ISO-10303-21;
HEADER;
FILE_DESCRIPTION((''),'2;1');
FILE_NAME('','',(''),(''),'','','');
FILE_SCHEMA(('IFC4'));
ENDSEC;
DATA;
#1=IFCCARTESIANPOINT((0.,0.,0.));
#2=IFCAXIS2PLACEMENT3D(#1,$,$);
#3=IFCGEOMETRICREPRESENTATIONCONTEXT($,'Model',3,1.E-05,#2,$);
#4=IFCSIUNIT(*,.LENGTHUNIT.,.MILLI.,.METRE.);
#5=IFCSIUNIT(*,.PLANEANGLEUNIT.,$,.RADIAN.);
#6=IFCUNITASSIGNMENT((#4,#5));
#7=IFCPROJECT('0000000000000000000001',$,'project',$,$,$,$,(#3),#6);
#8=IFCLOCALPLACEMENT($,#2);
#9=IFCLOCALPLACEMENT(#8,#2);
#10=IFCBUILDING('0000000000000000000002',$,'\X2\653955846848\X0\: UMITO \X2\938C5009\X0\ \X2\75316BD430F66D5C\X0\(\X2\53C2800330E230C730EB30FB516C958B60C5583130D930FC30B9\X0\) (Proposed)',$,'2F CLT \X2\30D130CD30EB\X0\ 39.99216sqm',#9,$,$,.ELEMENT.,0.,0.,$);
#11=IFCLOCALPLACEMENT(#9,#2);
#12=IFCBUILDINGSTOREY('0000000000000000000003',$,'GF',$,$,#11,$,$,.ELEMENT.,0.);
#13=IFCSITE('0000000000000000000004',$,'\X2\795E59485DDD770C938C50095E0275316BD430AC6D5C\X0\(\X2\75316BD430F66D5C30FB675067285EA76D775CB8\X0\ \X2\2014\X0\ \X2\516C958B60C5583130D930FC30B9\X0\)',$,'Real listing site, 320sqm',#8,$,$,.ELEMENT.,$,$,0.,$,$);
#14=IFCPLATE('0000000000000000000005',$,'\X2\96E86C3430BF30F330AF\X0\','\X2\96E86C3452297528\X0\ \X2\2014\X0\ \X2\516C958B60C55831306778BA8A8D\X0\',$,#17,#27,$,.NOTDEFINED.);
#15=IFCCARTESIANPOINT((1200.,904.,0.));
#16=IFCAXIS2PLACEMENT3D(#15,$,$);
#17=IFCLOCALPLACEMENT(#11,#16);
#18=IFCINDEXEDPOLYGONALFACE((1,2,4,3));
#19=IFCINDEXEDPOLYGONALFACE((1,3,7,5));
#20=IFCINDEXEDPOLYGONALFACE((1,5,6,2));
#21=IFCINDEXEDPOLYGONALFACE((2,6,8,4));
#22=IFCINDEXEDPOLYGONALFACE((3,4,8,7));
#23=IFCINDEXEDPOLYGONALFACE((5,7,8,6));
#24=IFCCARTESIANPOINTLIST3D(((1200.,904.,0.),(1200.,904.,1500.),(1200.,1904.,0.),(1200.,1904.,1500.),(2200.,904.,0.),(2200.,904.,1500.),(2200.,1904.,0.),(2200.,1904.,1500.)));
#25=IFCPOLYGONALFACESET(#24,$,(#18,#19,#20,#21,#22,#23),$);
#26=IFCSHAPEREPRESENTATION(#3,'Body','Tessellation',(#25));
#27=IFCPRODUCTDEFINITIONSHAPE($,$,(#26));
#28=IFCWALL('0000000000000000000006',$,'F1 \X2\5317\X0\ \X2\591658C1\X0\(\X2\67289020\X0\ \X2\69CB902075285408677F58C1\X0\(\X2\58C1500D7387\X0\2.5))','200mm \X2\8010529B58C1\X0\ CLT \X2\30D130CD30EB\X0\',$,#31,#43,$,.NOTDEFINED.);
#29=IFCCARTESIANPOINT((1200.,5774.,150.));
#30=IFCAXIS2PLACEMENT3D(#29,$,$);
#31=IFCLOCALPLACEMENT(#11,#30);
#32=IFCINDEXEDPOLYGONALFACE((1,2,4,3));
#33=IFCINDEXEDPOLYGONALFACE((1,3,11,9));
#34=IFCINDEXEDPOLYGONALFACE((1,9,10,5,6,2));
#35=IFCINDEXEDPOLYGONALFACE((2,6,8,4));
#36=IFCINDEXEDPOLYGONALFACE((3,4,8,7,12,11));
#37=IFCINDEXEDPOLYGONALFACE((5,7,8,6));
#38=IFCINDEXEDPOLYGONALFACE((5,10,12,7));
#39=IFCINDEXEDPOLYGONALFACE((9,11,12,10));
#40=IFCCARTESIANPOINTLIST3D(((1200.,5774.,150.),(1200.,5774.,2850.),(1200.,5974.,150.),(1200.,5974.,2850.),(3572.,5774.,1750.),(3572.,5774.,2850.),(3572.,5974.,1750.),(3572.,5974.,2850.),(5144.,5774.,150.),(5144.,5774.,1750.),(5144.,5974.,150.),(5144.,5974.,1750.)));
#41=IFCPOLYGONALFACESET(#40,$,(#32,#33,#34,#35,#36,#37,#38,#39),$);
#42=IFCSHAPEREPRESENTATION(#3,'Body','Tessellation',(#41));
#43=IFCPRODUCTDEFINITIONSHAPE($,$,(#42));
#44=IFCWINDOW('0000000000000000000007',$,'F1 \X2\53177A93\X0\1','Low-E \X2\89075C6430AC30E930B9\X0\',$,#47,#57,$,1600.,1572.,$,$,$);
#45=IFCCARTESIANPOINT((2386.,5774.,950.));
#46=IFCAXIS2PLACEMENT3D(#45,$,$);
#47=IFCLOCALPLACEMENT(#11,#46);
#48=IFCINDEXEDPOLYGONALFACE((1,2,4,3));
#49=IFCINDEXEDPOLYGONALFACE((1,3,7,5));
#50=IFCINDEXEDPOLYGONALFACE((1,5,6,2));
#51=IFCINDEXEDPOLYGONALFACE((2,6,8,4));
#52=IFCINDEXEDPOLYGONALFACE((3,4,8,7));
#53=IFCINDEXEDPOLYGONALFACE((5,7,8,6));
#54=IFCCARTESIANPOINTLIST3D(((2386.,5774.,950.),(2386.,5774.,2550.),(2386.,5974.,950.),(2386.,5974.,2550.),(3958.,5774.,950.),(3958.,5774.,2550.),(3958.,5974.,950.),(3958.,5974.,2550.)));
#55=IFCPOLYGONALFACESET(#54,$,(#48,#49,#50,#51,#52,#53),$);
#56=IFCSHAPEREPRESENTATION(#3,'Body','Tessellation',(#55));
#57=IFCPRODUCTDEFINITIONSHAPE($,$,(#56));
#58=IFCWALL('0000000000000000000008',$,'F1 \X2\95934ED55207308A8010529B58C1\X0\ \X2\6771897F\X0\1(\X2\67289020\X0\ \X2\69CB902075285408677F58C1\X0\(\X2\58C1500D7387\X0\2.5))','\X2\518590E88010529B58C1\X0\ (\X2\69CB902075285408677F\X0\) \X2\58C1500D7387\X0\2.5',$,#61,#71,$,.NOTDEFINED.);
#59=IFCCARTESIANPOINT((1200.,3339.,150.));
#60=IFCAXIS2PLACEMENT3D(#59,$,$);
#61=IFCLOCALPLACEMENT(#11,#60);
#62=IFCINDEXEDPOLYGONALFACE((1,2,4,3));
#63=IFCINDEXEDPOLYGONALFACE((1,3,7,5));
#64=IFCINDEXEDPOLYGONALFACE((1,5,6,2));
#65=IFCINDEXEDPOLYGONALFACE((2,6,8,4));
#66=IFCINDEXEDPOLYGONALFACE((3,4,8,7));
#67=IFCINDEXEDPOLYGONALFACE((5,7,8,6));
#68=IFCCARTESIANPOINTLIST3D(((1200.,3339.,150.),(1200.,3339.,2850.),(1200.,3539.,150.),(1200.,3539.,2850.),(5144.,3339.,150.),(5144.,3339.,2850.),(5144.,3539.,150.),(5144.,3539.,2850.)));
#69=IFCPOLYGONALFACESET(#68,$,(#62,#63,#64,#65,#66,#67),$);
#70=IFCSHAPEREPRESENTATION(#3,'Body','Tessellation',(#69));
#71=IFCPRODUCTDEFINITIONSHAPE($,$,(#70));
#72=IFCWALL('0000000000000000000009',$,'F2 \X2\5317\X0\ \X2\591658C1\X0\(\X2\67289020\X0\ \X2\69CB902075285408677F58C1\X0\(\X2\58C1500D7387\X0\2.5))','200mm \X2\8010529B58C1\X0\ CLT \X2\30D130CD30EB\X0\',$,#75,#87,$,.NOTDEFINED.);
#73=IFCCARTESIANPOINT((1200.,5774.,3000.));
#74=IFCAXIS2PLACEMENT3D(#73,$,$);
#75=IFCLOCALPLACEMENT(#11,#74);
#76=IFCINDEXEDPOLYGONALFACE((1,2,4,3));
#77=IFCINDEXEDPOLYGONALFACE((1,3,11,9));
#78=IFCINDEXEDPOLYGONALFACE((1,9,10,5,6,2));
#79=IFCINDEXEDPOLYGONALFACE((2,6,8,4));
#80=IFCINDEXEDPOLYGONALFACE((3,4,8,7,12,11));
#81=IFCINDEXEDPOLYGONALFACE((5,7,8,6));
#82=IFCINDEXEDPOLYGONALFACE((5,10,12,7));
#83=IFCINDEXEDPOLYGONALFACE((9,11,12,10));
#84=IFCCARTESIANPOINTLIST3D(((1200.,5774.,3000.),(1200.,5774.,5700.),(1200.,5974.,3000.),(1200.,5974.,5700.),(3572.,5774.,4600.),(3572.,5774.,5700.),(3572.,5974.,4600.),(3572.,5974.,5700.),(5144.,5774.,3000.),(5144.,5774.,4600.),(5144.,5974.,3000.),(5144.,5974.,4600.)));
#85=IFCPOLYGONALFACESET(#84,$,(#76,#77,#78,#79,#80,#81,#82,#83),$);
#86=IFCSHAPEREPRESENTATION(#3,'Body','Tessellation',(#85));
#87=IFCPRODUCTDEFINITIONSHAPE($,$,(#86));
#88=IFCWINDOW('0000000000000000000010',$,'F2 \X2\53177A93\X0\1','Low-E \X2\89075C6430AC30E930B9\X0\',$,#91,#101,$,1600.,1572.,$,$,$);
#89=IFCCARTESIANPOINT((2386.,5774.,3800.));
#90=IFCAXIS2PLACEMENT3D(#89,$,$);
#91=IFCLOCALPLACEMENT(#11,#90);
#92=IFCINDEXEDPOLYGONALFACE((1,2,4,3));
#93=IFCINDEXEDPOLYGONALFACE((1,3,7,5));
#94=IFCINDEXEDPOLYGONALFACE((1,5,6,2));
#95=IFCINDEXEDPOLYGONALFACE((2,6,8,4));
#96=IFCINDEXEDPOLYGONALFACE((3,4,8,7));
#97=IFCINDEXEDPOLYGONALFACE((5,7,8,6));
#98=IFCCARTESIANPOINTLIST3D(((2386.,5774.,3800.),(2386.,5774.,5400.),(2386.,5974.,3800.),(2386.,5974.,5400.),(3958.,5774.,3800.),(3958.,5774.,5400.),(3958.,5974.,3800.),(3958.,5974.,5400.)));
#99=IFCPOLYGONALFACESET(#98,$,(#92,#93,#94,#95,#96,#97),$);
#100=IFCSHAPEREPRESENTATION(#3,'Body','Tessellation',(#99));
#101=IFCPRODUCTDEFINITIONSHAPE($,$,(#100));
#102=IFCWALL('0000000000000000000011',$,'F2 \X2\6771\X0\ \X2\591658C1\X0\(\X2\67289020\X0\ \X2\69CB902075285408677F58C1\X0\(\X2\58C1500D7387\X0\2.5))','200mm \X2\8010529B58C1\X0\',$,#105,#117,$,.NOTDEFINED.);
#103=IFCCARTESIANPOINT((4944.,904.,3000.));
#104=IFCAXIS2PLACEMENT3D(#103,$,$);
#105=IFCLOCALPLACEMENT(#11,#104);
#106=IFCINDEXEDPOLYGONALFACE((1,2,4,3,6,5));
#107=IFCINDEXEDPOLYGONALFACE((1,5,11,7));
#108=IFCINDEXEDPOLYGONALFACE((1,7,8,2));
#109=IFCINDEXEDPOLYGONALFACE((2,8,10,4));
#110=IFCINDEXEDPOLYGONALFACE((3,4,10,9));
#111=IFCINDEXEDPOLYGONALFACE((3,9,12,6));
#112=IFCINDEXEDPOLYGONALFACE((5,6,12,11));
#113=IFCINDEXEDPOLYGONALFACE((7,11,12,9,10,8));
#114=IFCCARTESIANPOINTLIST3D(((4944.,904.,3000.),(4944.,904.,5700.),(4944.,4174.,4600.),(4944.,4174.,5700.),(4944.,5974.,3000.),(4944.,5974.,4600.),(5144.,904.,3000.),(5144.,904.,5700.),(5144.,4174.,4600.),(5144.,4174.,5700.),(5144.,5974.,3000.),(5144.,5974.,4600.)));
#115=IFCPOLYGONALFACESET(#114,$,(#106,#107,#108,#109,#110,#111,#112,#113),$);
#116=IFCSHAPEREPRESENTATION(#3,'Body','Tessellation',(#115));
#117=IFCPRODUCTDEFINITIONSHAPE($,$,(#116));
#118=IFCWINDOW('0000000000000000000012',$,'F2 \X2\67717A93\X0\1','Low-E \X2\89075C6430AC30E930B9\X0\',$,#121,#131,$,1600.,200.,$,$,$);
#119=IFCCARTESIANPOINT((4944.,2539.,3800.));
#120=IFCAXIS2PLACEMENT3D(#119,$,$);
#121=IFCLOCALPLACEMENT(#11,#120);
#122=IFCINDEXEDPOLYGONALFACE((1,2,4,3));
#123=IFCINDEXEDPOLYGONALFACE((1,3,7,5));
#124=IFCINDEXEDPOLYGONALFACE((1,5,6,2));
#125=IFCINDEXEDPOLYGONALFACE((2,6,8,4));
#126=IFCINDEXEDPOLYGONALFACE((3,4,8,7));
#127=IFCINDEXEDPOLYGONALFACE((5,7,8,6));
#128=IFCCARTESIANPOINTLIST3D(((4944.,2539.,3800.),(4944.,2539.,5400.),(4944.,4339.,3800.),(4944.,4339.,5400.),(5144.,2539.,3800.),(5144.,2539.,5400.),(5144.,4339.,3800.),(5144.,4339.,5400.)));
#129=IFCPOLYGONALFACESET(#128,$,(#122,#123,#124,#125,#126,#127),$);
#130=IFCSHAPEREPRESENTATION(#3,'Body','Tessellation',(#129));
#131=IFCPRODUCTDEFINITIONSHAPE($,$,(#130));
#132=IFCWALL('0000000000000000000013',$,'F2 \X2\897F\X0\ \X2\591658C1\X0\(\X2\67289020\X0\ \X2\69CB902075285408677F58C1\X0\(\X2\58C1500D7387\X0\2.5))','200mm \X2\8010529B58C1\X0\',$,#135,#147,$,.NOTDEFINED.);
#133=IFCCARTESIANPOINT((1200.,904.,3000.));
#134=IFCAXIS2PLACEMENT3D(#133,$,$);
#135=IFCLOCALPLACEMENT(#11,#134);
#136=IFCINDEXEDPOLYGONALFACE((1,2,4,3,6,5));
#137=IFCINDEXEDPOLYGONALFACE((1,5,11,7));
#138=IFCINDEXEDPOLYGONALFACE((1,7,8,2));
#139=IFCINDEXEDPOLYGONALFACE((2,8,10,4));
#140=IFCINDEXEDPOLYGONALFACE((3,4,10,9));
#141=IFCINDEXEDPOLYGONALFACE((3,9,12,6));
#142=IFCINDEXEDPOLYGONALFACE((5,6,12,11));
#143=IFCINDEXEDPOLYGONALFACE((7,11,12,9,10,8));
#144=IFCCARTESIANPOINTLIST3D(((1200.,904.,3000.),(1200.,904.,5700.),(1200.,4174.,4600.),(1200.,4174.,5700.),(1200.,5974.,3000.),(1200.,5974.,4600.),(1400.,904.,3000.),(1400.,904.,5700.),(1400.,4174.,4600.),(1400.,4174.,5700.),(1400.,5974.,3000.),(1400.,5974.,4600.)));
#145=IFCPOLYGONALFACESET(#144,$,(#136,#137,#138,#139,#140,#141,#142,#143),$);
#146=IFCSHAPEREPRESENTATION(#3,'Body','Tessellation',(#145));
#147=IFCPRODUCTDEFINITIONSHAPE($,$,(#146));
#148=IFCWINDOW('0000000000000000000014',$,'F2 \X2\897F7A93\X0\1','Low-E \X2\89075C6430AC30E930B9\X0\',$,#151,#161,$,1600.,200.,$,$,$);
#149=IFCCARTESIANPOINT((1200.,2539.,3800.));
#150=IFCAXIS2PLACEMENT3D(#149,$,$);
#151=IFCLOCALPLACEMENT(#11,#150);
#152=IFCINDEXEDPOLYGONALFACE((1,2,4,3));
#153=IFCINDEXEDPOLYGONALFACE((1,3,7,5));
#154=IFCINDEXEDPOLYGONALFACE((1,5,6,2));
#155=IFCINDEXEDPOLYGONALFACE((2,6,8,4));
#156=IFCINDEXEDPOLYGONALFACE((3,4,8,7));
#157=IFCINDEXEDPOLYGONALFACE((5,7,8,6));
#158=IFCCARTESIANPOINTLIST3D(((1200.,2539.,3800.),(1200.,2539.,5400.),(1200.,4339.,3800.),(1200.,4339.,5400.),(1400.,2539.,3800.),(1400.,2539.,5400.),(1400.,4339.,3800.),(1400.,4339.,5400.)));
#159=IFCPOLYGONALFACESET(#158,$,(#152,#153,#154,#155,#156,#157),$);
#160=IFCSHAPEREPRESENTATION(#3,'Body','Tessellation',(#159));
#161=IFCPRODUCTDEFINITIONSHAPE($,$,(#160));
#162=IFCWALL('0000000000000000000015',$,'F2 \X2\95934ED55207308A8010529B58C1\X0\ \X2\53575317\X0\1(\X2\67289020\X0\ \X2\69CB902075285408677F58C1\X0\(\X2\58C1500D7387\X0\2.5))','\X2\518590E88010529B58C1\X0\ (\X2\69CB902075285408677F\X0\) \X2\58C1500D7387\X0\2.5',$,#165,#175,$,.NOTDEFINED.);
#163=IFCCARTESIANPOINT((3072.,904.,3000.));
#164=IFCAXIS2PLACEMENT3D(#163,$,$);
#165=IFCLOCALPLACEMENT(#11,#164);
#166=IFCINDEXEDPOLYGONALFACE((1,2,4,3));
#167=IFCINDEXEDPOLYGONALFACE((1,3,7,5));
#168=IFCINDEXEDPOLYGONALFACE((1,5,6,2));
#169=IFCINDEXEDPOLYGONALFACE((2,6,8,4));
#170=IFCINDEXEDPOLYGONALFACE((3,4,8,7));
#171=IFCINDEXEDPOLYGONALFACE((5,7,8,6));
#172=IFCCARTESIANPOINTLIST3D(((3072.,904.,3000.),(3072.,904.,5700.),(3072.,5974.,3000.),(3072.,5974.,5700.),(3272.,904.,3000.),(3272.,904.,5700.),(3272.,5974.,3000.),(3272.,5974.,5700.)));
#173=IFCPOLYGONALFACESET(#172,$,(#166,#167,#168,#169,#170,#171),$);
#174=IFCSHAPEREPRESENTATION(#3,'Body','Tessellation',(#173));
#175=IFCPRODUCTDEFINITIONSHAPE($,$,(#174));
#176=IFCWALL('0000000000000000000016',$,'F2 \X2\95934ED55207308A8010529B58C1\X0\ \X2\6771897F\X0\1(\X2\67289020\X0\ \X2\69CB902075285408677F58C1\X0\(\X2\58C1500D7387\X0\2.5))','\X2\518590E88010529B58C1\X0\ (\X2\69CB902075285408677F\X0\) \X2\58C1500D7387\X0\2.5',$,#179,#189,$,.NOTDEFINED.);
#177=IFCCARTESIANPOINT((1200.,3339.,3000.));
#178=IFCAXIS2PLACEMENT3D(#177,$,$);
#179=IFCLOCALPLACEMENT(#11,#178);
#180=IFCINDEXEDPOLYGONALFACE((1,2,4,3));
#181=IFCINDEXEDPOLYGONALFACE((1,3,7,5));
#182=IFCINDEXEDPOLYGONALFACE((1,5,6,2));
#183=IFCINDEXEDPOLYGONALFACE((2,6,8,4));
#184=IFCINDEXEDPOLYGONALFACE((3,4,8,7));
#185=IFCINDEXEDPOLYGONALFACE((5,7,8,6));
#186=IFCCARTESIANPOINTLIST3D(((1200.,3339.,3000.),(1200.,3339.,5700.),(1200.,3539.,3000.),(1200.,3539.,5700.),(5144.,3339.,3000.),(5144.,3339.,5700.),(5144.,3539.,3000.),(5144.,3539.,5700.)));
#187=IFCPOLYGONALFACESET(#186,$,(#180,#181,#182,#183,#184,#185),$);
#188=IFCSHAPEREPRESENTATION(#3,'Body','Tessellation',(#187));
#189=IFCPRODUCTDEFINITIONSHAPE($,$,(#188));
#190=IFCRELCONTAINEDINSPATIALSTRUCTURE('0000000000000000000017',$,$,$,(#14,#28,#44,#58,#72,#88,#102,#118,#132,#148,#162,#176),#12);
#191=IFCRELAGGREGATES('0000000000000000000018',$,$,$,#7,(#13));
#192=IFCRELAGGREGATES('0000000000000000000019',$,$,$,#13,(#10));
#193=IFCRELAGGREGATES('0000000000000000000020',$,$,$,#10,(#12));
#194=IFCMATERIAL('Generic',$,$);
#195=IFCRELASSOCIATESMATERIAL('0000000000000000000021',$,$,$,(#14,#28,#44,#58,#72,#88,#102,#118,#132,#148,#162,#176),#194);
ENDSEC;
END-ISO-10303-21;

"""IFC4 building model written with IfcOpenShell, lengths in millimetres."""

from ifc_helpers import new_model, si_unit, frame, frame_2d, origin, place, context, project, spatial, rectangle, extrude, material, element, fill, save


model = new_model("IFC4")

# Units and contexts
model_context = context("Model", 3, precision=1e-05, world=origin())
ifc_project = project(units=[si_unit("LENGTHUNIT", "METRE", prefix="MILLI"), si_unit("PLANEANGLEUNIT", "RADIAN")], contexts=[model_context])

# Site, building, storey
site_placement = place(None, origin())
site = spatial("IfcSite", under=ifc_project, at=site_placement, Name="神奈川県鎌倉市由比ガ浜(由比ヶ浜・材木座海岸 — 公開情報ベース)", ObjectType="Real listing site, 320sqm", CompositionType="ELEMENT", RefElevation=0.0)
building_placement = place(site_placement, origin())
building = spatial("IfcBuilding", under=site, at=building_placement, Name="改善案: UMITO 鎌倉 由比ヶ浜(参考モデル・公開情報ベース) (Proposed)", ObjectType="2F CLT パネル 39.99216sqm", CompositionType="ELEMENT", ElevationOfRefHeight=0.0, ElevationOfTerrain=0.0)
storey_placement = place(building_placement, origin())
storey = spatial("IfcBuildingStorey", under=building, at=storey_placement, Name="GF", CompositionType="ELEMENT", Elevation=0.0)

# Plate
ifc_material_1 = material(Name="Generic")
plate_placement = place(storey_placement, frame((1200.0, 904.0, 0.0)))
element("IfcPlate", 1, at=plate_placement, inside=storey, material=ifc_material_1, Name="雨水タンク", Description="雨水利用 — 公開情報で確認", PredefinedType="NOTDEFINED", context=model_context, shape_type="SweptSolid", body=[
    extrude(rectangle(XDim=1000.0, YDim=1000.0, at=frame_2d((500.0, 500.0))), frame((1200.0, 904.0, 0.0)), (0.0, 0.0, 1.0), 1500.0),
])

# Wall, opening, window
wall_1_placement = place(storey_placement, frame((1200.0, 5774.0, 150.0)))
wall_1 = element("IfcWall", 2, at=wall_1_placement, inside=storey, material=ifc_material_1, Name="F1 北 外壁(木造 構造用合板壁(壁倍率2.5))", Description="200mm 耐力壁 CLT パネル", PredefinedType="NOTDEFINED", context=model_context, shape_type="SweptSolid", body=[
    extrude(rectangle(XDim=3944.0, YDim=200.0, at=frame_2d((1972.0, 100.0))), frame((1200.0, 5774.0, 150.0)), (0.0, 0.0, 1.0), 2700.0),
])
opening_1_placement = place(storey_placement, frame((2386.0, 5774.0, 950.0)))
opening_1 = element("IfcOpeningElement", 3, at=opening_1_placement, cuts=wall_1, PredefinedType="NOTDEFINED", context=model_context, shape_type="SweptSolid", body=[
    extrude(rectangle(XDim=1572.0, YDim=200.0, at=frame_2d((786.0, 100.0))), frame((2386.0, 5774.0, 950.0)), (0.0, 0.0, 1.0), 1600.0),
])
window_1_placement = place(storey_placement, frame((2386.0, 5774.0, 950.0)))
window_1 = element("IfcWindow", 4, at=window_1_placement, inside=storey, material=ifc_material_1, Name="F1 北窓1", Description="Low-E 複層ガラス", OverallHeight=1600.0, OverallWidth=1572.0, context=model_context, shape_type="SweptSolid", body=[
    extrude(rectangle(XDim=1572.0, YDim=200.0, at=frame_2d((786.0, 100.0))), frame((2386.0, 5774.0, 950.0)), (0.0, 0.0, 1.0), 1600.0),
])
fill(opening_1, window_1)

# Wall
wall_2_placement = place(storey_placement, frame((1200.0, 3339.0, 150.0)))
element("IfcWall", 5, at=wall_2_placement, inside=storey, material=ifc_material_1, Name="F1 間仕切り耐力壁 東西1(木造 構造用合板壁(壁倍率2.5))", Description="内部耐力壁 (構造用合板) 壁倍率2.5", PredefinedType="NOTDEFINED", context=model_context, shape_type="SweptSolid", body=[
    extrude(rectangle(XDim=3944.0, YDim=200.0, at=frame_2d((1972.0, 100.0))), frame((1200.0, 3339.0, 150.0)), (0.0, 0.0, 1.0), 2700.0),
])

# Walls, openings, windows
wall_3_placement = place(storey_placement, frame((1200.0, 5774.0, 3000.0)))
wall_3 = element("IfcWall", 6, at=wall_3_placement, inside=storey, material=ifc_material_1, Name="F2 北 外壁(木造 構造用合板壁(壁倍率2.5))", Description="200mm 耐力壁 CLT パネル", PredefinedType="NOTDEFINED", context=model_context, shape_type="SweptSolid", body=[
    extrude(rectangle(XDim=3944.0, YDim=200.0, at=frame_2d((1972.0, 100.0))), frame((1200.0, 5774.0, 3000.0)), (0.0, 0.0, 1.0), 2700.0),
])
opening_2_placement = place(storey_placement, frame((2386.0, 5774.0, 3800.0)))
opening_2 = element("IfcOpeningElement", 7, at=opening_2_placement, cuts=wall_3, PredefinedType="NOTDEFINED", context=model_context, shape_type="SweptSolid", body=[
    extrude(rectangle(XDim=1572.0, YDim=200.0, at=frame_2d((786.0, 100.0))), frame((2386.0, 5774.0, 3800.0)), (0.0, 0.0, 1.0), 1600.0),
])
window_2_placement = place(storey_placement, frame((2386.0, 5774.0, 3800.0)))
window_2 = element("IfcWindow", 8, at=window_2_placement, inside=storey, material=ifc_material_1, Name="F2 北窓1", Description="Low-E 複層ガラス", OverallHeight=1600.0, OverallWidth=1572.0, context=model_context, shape_type="SweptSolid", body=[
    extrude(rectangle(XDim=1572.0, YDim=200.0, at=frame_2d((786.0, 100.0))), frame((2386.0, 5774.0, 3800.0)), (0.0, 0.0, 1.0), 1600.0),
])
fill(opening_2, window_2)
wall_4_placement = place(storey_placement, frame((4944.0, 904.0, 3000.0)))
wall_4 = element("IfcWall", 9, at=wall_4_placement, inside=storey, material=ifc_material_1, Name="F2 東 外壁(木造 構造用合板壁(壁倍率2.5))", Description="200mm 耐力壁", PredefinedType="NOTDEFINED", context=model_context, shape_type="SweptSolid", body=[
    extrude(rectangle(XDim=200.0, YDim=5070.0, at=frame_2d((100.0, 2535.0))), frame((4944.0, 904.0, 3000.0)), (0.0, 0.0, 1.0), 2700.0),
])
opening_3_placement = place(storey_placement, frame((4944.0, 2539.0, 3800.0)))
opening_3 = element("IfcOpeningElement", 10, at=opening_3_placement, cuts=wall_4, PredefinedType="NOTDEFINED", context=model_context, shape_type="SweptSolid", body=[
    extrude(rectangle(XDim=200.0, YDim=1800.0, at=frame_2d((100.0, 900.0))), frame((4944.0, 2539.0, 3800.0)), (0.0, 0.0, 1.0), 1600.0),
])
window_3_placement = place(storey_placement, frame((4944.0, 2539.0, 3800.0)))
window_3 = element("IfcWindow", 11, at=window_3_placement, inside=storey, material=ifc_material_1, Name="F2 東窓1", Description="Low-E 複層ガラス", OverallHeight=1600.0, OverallWidth=200.0, context=model_context, shape_type="SweptSolid", body=[
    extrude(rectangle(XDim=200.0, YDim=1800.0, at=frame_2d((100.0, 900.0))), frame((4944.0, 2539.0, 3800.0)), (0.0, 0.0, 1.0), 1600.0),
])
fill(opening_3, window_3)
wall_5_placement = place(storey_placement, frame((1200.0, 904.0, 3000.0)))
wall_5 = element("IfcWall", 12, at=wall_5_placement, inside=storey, material=ifc_material_1, Name="F2 西 外壁(木造 構造用合板壁(壁倍率2.5))", Description="200mm 耐力壁", PredefinedType="NOTDEFINED", context=model_context, shape_type="SweptSolid", body=[
    extrude(rectangle(XDim=200.0, YDim=5070.0, at=frame_2d((100.0, 2535.0))), frame((1200.0, 904.0, 3000.0)), (0.0, 0.0, 1.0), 2700.0),
])
opening_4_placement = place(storey_placement, frame((1200.0, 2539.0, 3800.0)))
opening_4 = element("IfcOpeningElement", 13, at=opening_4_placement, cuts=wall_5, PredefinedType="NOTDEFINED", context=model_context, shape_type="SweptSolid", body=[
    extrude(rectangle(XDim=200.0, YDim=1800.0, at=frame_2d((100.0, 900.0))), frame((1200.0, 2539.0, 3800.0)), (0.0, 0.0, 1.0), 1600.0),
])
window_4_placement = place(storey_placement, frame((1200.0, 2539.0, 3800.0)))
window_4 = element("IfcWindow", 14, at=window_4_placement, inside=storey, material=ifc_material_1, Name="F2 西窓1", Description="Low-E 複層ガラス", OverallHeight=1600.0, OverallWidth=200.0, context=model_context, shape_type="SweptSolid", body=[
    extrude(rectangle(XDim=200.0, YDim=1800.0, at=frame_2d((100.0, 900.0))), frame((1200.0, 2539.0, 3800.0)), (0.0, 0.0, 1.0), 1600.0),
])
fill(opening_4, window_4)

# Walls
wall_6_placement = place(storey_placement, frame((3072.0, 904.0, 3000.0)))
element("IfcWall", 15, at=wall_6_placement, inside=storey, material=ifc_material_1, Name="F2 間仕切り耐力壁 南北1(木造 構造用合板壁(壁倍率2.5))", Description="内部耐力壁 (構造用合板) 壁倍率2.5", PredefinedType="NOTDEFINED", context=model_context, shape_type="SweptSolid", body=[
    extrude(rectangle(XDim=200.0, YDim=5070.0, at=frame_2d((100.0, 2535.0))), frame((3072.0, 904.0, 3000.0)), (0.0, 0.0, 1.0), 2700.0),
])
wall_7_placement = place(storey_placement, frame((1200.0, 3339.0, 3000.0)))
element("IfcWall", 16, at=wall_7_placement, inside=storey, material=ifc_material_1, Name="F2 間仕切り耐力壁 東西1(木造 構造用合板壁(壁倍率2.5))", Description="内部耐力壁 (構造用合板) 壁倍率2.5", PredefinedType="NOTDEFINED", context=model_context, shape_type="SweptSolid", body=[
    extrude(rectangle(XDim=3944.0, YDim=200.0, at=frame_2d((1972.0, 100.0))), frame((1200.0, 3339.0, 3000.0)), (0.0, 0.0, 1.0), 2700.0),
])

save(model, "model.ifc")
